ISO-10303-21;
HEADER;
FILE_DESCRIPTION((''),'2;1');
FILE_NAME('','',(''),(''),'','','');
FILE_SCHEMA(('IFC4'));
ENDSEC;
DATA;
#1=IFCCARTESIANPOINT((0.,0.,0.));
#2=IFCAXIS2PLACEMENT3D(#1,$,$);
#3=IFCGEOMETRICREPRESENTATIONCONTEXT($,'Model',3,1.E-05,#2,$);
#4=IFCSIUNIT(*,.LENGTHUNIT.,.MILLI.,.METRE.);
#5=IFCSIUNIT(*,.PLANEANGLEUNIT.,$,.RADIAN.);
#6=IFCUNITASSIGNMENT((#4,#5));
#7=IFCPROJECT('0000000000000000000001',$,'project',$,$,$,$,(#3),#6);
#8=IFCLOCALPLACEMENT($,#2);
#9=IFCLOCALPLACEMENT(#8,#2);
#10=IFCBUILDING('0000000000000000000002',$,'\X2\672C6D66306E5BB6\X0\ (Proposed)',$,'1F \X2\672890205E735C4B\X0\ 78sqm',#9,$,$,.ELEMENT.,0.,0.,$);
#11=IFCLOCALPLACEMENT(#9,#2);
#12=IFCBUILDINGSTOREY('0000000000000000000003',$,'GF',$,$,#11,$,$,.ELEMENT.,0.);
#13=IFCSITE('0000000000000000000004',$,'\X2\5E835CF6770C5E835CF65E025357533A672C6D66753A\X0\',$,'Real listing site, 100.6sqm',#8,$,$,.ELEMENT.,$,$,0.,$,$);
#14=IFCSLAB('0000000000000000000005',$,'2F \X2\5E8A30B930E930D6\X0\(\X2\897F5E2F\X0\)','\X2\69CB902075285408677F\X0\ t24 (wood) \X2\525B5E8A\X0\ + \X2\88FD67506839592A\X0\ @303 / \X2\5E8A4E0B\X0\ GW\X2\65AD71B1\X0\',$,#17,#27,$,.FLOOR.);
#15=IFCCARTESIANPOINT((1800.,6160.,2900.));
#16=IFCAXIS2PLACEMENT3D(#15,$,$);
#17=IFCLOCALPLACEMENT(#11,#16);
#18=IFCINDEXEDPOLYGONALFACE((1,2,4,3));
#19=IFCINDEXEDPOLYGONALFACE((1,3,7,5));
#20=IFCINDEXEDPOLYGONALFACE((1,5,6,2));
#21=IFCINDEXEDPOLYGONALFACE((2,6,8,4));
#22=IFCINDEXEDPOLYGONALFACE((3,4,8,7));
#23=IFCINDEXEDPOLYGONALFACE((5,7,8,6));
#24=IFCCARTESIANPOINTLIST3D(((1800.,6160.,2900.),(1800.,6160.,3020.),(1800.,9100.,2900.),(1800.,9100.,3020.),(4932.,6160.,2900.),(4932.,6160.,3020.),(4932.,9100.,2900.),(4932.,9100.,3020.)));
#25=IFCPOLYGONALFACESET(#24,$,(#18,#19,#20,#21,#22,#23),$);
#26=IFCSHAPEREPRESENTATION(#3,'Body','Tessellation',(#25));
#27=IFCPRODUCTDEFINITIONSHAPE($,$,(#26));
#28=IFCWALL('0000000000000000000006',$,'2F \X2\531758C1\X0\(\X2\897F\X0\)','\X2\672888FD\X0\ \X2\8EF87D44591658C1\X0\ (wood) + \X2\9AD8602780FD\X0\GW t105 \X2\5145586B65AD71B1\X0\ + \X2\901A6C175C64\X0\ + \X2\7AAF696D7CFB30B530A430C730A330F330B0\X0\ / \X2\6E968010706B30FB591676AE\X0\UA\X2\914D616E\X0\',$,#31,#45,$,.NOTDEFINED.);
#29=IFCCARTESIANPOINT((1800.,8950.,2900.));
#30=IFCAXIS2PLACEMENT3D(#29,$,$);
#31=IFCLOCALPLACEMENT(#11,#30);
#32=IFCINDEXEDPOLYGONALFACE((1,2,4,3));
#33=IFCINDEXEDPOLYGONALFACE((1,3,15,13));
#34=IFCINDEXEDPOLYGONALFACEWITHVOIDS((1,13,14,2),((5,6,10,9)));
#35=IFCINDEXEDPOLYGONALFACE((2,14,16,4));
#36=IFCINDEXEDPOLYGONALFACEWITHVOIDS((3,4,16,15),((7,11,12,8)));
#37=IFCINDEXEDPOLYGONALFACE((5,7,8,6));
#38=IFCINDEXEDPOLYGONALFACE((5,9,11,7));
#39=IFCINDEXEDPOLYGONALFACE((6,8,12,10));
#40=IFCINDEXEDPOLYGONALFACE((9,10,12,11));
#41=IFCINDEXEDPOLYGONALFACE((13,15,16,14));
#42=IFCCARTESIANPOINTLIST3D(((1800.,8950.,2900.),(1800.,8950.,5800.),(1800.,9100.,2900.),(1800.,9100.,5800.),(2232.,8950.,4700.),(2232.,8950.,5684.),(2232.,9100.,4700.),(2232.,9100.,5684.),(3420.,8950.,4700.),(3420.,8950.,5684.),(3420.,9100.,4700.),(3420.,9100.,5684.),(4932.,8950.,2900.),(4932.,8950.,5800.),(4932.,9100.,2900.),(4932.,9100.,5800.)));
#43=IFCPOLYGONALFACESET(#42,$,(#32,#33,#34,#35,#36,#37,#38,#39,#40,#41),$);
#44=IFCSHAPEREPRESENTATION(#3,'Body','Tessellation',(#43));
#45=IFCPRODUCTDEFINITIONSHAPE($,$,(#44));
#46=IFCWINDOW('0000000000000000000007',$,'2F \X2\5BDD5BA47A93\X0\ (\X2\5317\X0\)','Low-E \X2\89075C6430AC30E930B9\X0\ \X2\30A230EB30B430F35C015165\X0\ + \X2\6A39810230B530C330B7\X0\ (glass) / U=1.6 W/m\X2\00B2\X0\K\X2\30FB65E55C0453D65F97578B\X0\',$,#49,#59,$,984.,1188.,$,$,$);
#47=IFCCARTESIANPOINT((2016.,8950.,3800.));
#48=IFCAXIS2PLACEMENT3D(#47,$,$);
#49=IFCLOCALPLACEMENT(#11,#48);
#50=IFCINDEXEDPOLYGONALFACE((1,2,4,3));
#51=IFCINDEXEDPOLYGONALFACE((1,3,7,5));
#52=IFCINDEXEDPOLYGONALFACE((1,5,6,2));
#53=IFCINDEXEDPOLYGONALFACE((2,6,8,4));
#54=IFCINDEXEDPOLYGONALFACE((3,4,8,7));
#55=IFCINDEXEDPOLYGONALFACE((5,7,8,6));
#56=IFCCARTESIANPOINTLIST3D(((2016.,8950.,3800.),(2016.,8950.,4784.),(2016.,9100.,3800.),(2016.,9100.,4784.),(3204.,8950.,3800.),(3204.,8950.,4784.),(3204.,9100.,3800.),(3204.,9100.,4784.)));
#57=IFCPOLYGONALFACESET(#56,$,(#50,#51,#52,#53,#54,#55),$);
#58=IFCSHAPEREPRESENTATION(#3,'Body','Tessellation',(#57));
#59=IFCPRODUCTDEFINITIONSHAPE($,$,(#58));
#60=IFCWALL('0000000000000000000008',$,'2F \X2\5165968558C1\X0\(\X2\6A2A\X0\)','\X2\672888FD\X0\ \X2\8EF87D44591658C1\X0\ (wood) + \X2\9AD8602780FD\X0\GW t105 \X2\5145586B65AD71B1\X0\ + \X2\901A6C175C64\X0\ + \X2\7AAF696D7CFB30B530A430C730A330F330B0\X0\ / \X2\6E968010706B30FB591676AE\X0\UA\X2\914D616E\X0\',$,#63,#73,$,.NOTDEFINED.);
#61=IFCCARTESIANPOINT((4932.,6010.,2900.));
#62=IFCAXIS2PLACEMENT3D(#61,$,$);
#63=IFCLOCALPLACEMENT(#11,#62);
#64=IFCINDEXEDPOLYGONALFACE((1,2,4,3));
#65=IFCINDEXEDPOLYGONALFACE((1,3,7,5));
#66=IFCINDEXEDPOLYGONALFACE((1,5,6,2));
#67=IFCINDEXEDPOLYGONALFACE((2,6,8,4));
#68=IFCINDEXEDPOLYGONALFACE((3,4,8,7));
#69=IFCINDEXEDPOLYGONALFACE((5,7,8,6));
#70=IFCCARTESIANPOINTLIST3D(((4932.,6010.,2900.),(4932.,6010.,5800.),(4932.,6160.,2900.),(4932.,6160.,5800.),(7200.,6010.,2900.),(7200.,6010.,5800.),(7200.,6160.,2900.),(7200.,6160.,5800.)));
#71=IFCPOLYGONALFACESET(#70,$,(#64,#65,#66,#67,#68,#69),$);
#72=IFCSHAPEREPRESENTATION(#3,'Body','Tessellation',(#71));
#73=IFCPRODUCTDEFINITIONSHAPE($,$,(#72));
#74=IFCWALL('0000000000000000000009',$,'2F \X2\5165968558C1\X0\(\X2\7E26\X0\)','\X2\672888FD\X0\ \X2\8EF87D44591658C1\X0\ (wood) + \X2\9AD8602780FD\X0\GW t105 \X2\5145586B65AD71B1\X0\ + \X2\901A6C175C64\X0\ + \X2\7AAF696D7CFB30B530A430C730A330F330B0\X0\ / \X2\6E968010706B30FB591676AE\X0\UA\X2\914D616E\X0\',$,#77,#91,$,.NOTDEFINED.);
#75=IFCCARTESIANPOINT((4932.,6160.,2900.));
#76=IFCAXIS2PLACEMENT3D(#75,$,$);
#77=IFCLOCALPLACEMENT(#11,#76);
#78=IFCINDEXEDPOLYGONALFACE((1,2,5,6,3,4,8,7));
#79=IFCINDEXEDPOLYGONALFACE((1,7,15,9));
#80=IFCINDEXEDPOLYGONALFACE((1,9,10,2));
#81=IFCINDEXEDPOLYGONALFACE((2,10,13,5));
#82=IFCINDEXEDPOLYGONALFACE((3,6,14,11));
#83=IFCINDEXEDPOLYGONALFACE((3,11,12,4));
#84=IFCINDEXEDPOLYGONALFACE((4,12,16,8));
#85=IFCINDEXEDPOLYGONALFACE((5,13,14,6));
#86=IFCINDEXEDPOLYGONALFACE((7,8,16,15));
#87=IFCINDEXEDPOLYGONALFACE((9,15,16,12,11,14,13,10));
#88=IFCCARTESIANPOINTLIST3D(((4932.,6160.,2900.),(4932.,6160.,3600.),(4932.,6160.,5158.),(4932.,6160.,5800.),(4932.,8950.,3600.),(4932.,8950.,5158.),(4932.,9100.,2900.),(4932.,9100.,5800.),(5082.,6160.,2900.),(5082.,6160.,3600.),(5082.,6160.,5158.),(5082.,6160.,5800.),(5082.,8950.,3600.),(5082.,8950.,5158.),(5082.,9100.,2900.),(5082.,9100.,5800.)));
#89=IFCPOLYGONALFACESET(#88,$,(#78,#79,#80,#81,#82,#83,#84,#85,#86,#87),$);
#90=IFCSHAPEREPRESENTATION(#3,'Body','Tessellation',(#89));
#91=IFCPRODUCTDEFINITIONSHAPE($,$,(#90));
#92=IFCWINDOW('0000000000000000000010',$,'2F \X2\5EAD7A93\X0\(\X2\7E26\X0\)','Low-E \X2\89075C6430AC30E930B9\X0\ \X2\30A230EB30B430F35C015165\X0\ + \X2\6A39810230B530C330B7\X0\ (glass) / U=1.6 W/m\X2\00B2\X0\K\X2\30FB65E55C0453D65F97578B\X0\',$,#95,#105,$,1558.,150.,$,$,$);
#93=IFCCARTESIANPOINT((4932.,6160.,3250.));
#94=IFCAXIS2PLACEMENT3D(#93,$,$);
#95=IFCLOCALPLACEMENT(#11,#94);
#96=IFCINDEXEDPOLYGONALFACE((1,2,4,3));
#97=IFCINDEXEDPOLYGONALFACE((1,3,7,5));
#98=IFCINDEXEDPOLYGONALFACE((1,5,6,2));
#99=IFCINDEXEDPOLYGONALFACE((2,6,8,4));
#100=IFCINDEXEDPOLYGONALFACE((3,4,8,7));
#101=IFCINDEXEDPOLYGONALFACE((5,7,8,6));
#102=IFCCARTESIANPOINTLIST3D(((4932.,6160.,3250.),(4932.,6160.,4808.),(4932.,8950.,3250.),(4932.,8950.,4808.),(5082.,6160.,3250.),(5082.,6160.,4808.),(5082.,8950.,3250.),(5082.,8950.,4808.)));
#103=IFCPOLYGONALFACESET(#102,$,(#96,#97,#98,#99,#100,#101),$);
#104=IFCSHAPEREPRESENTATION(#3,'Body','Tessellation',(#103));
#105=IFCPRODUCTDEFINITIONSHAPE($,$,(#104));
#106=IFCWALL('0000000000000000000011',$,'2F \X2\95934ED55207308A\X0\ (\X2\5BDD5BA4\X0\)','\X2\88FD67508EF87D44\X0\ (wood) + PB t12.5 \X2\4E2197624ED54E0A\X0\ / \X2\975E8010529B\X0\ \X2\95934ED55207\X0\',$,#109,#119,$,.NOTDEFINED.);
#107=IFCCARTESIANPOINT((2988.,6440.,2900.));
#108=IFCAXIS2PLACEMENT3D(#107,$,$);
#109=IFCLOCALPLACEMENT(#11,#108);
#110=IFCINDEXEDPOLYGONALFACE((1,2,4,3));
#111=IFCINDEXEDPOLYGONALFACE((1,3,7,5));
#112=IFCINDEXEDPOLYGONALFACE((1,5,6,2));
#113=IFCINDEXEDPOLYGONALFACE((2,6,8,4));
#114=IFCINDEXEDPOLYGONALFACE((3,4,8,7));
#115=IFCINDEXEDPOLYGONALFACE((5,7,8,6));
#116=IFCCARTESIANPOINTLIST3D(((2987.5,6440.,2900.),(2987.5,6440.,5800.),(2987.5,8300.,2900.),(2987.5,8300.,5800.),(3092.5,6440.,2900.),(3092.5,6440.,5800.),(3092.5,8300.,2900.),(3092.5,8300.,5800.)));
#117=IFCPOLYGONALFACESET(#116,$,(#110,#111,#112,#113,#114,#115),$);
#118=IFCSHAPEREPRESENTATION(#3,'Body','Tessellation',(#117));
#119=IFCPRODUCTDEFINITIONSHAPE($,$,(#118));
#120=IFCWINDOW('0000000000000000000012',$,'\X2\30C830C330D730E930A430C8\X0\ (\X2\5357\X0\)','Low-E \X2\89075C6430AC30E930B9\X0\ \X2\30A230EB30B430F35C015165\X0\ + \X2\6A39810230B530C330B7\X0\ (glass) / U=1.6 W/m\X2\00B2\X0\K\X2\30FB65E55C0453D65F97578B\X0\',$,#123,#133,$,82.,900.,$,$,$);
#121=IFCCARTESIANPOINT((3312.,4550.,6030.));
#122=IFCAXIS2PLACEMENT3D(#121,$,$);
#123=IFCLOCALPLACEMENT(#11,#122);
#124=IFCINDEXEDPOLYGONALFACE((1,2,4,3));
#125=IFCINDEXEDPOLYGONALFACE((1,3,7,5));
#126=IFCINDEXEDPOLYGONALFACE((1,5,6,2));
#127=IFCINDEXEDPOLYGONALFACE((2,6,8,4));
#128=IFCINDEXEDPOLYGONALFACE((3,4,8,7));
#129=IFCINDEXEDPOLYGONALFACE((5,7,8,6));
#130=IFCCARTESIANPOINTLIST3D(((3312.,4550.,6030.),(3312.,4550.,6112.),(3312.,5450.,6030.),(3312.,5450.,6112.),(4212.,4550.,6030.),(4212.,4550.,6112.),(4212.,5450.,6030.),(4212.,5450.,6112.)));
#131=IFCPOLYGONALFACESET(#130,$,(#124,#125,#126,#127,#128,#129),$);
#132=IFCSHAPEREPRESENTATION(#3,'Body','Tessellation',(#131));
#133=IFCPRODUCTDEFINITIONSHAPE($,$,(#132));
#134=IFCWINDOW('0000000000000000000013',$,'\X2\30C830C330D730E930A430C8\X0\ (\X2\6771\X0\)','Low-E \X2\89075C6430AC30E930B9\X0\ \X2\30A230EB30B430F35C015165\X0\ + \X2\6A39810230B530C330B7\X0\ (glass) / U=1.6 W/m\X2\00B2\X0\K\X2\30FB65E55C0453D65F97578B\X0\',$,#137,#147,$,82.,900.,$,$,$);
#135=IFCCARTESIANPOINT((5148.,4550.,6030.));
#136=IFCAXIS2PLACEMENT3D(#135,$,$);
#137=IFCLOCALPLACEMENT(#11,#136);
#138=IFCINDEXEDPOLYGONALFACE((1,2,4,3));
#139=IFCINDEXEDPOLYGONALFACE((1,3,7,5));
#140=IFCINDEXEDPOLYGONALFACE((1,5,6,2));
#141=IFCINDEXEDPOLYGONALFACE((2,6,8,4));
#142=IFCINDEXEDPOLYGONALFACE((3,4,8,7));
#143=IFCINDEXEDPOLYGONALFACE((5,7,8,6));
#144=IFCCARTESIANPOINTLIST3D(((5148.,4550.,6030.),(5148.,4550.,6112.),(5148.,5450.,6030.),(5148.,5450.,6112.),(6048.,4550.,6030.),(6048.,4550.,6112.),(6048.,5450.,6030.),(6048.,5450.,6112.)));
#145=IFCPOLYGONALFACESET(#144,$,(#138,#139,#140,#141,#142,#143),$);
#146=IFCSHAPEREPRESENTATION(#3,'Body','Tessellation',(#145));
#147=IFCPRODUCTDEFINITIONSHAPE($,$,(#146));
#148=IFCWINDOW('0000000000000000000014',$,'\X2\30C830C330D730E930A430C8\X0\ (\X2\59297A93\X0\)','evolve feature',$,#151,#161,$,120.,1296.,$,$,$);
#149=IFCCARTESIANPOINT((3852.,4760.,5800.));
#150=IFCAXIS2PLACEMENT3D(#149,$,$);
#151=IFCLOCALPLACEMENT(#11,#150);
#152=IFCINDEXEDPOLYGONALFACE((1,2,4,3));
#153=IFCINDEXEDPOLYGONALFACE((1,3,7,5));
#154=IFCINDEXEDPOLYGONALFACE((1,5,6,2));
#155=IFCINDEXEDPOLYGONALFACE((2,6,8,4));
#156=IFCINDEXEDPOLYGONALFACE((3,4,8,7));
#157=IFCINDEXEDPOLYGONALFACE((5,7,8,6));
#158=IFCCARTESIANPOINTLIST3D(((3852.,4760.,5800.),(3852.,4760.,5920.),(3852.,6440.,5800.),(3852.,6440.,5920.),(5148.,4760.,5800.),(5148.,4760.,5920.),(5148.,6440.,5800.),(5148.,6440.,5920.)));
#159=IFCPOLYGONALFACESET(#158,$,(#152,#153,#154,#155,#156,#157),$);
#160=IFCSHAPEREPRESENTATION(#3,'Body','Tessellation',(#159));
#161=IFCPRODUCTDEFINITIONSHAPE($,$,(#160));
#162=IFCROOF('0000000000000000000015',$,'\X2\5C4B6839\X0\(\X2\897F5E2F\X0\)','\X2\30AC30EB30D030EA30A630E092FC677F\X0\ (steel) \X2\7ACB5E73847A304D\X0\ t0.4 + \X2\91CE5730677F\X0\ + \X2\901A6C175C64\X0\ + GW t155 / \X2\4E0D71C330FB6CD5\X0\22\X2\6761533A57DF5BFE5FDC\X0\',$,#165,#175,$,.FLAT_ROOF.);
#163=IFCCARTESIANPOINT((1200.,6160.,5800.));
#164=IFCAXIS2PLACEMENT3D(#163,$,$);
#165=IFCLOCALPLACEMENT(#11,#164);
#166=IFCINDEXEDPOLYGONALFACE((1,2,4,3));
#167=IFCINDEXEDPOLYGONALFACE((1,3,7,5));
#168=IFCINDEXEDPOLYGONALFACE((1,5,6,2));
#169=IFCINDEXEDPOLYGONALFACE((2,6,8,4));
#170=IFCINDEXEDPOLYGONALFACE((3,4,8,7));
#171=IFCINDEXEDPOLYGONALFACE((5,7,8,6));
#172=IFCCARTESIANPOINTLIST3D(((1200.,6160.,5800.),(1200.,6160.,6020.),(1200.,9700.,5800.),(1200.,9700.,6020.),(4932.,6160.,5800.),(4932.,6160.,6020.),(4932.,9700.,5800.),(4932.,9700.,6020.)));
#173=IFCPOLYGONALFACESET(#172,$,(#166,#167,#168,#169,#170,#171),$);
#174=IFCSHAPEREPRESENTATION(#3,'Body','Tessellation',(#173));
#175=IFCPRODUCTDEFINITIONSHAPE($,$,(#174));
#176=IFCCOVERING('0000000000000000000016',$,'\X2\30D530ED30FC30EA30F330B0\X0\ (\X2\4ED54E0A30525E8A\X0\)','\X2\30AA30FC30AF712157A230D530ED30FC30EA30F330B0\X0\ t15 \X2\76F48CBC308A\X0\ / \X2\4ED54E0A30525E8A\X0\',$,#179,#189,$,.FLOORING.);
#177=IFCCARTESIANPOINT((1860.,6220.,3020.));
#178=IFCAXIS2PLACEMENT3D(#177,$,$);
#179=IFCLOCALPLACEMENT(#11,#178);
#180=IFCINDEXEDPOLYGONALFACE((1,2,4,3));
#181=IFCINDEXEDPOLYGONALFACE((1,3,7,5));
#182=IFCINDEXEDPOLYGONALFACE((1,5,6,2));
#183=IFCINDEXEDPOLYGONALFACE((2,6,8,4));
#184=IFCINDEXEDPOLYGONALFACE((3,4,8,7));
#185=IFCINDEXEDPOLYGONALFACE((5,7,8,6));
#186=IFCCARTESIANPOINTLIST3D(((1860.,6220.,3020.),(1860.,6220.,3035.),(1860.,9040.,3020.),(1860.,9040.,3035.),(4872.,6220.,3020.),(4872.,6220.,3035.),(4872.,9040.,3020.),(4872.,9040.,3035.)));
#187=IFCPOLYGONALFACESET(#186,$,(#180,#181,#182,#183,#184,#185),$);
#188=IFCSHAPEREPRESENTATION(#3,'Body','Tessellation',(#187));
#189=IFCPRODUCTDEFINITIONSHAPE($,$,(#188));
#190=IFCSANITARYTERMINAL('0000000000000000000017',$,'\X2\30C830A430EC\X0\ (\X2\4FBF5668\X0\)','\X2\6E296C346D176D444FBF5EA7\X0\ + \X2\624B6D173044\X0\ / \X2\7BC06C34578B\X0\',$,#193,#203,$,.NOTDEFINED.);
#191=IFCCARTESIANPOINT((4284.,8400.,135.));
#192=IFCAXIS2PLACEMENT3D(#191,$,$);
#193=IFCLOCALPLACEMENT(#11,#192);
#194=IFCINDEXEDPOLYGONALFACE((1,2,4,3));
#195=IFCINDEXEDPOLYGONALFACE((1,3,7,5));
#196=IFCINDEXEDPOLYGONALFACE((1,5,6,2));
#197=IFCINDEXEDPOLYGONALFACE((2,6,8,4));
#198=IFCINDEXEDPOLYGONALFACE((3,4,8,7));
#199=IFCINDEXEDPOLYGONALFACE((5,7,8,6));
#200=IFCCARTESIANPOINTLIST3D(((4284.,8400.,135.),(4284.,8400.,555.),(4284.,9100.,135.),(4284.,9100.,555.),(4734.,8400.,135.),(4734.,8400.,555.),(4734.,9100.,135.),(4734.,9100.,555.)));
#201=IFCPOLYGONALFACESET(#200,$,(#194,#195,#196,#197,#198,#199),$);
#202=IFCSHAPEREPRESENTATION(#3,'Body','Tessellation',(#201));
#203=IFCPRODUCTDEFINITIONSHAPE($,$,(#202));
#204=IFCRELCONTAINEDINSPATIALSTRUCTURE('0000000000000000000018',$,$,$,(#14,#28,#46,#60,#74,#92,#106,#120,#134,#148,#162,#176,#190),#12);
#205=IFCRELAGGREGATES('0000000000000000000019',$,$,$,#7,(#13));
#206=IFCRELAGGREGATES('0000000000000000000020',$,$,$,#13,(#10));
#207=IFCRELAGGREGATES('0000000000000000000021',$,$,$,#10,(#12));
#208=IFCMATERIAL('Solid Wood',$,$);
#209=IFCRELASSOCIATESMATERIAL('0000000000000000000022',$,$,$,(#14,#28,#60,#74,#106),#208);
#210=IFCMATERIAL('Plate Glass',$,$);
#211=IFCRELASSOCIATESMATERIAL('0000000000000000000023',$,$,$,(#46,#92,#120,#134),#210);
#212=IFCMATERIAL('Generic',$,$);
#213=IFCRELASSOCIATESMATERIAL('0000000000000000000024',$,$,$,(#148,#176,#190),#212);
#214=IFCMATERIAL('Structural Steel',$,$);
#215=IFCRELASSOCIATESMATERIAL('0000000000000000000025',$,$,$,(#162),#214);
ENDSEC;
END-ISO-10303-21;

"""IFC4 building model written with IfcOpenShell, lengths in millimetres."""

from ifc_helpers import new_model, si_unit, frame, frame_2d, origin, place, context, project, spatial, rectangle, extrude, material, element, fill, save


model = new_model("IFC4")

# Units and contexts
model_context = context("Model", 3, precision=1e-05, world=origin())
ifc_project = project(units=[si_unit("LENGTHUNIT", "METRE", prefix="MILLI"), si_unit("PLANEANGLEUNIT", "RADIAN")], contexts=[model_context])

# Site, building, storey
site_placement = place(None, origin())
site = spatial("IfcSite", under=ifc_project, at=site_placement, Name="広島県広島市南区本浦町", ObjectType="Real listing site, 100.6sqm", CompositionType="ELEMENT", RefElevation=0.0)
building_placement = place(site_placement, origin())
building = spatial("IfcBuilding", under=site, at=building_placement, Name="本浦の家 (Proposed)", ObjectType="1F 木造平屋 78sqm", CompositionType="ELEMENT", ElevationOfRefHeight=0.0, ElevationOfTerrain=0.0)
storey_placement = place(building_placement, origin())
storey = spatial("IfcBuildingStorey", under=building, at=storey_placement, Name="GF", CompositionType="ELEMENT", Elevation=0.0)

# Slab
ifc_material_1 = material(Name="Solid Wood")
slab_placement = place(storey_placement, frame((1800.0, 6160.0, 2900.0)))
element("IfcSlab", 1, at=slab_placement, inside=storey, material=ifc_material_1, Name="2F 床スラブ(西帯)", Description="構造用合板 t24 (wood) 剛床 + 製材根太 @303 / 床下 GW断熱", PredefinedType="FLOOR", context=model_context, shape_type="SweptSolid", body=[
    extrude(rectangle(XDim=3132.0, YDim=2940.0, at=frame_2d((1566.0, 1470.0))), frame((1800.0, 6160.0, 2900.0)), (0.0, 0.0, 1.0), 120.0),
])

# Wall, opening, window
wall_1_placement = place(storey_placement, frame((1800.0, 8950.0, 2900.0)))
wall_1 = element("IfcWall", 2, at=wall_1_placement, inside=storey, material=ifc_material_1, Name="2F 北壁(西)", Description="木製 軸組外壁 (wood) + 高性能GW t105 充填断熱 + 通気層 + 窯業系サイディング / 準耐火・外皮UA配慮", PredefinedType="NOTDEFINED", context=model_context, shape_type="SweptSolid", body=[
    extrude(rectangle(XDim=3132.0, YDim=150.0, at=frame_2d((1566.0, 75.0))), frame((1800.0, 8950.0, 2900.0)), (0.0, 0.0, 1.0), 2900.0),
])
opening_1_placement = place(storey_placement, frame((2016.0, 8950.0, 3800.0)))
opening_1 = element("IfcOpeningElement", 3, at=opening_1_placement, cuts=wall_1, PredefinedType="NOTDEFINED", context=model_context, shape_type="SweptSolid", body=[
    extrude(rectangle(XDim=1188.0, YDim=150.0, at=frame_2d((594.0, 75.0))), frame((2016.0, 8950.0, 3800.0)), (0.0, 0.0, 1.0), 984.0),
])
ifc_material_2 = material(Name="Plate Glass")
window_1_placement = place(storey_placement, frame((2016.0, 8950.0, 3800.0)))
window_1 = element("IfcWindow", 4, at=window_1_placement, inside=storey, material=ifc_material_2, Name="2F 寝室窓 (北)", Description="Low-E 複層ガラス アルゴン封入 + 樹脂サッシ (glass) / U=1.6 W/m²K・日射取得型", OverallHeight=984.0, OverallWidth=1188.0, context=model_context, shape_type="SweptSolid", body=[
    extrude(rectangle(XDim=1188.0, YDim=150.0, at=frame_2d((594.0, 75.0))), frame((2016.0, 8950.0, 3800.0)), (0.0, 0.0, 1.0), 984.0),
])
fill(opening_1, window_1)

# Wall
wall_2_placement = place(storey_placement, frame((4932.0, 6010.0, 2900.0)))
element("IfcWall", 5, at=wall_2_placement, inside=storey, material=ifc_material_1, Name="2F 入隅壁(横)", Description="木製 軸組外壁 (wood) + 高性能GW t105 充填断熱 + 通気層 + 窯業系サイディング / 準耐火・外皮UA配慮", PredefinedType="NOTDEFINED", context=model_context, shape_type="SweptSolid", body=[
    extrude(rectangle(XDim=2268.0, YDim=150.0, at=frame_2d((1134.0, 75.0))), frame((4932.0, 6010.0, 2900.0)), (0.0, 0.0, 1.0), 2900.0),
])

# Wall, opening, window
wall_3_placement = place(storey_placement, frame((4932.0, 6160.0, 2900.0)))
wall_3 = element("IfcWall", 6, at=wall_3_placement, inside=storey, material=ifc_material_1, Name="2F 入隅壁(縦)", Description="木製 軸組外壁 (wood) + 高性能GW t105 充填断熱 + 通気層 + 窯業系サイディング / 準耐火・外皮UA配慮", PredefinedType="NOTDEFINED", context=model_context, shape_type="SweptSolid", body=[
    extrude(rectangle(XDim=150.0, YDim=2940.0, at=frame_2d((75.0, 1470.0))), frame((4932.0, 6160.0, 2900.0)), (0.0, 0.0, 1.0), 2900.0),
])
opening_2_placement = place(storey_placement, frame((4932.0, 6160.0, 3250.0)))
opening_2 = element("IfcOpeningElement", 7, at=opening_2_placement, cuts=wall_3, PredefinedType="NOTDEFINED", context=model_context, shape_type="SweptSolid", body=[
    extrude(rectangle(XDim=150.0, YDim=2790.0, at=frame_2d((75.0, 1395.0))), frame((4932.0, 6160.0, 3250.0)), (0.0, 0.0, 1.0), 1558.0),
])
window_2_placement = place(storey_placement, frame((4932.0, 6160.0, 3250.0)))
window_2 = element("IfcWindow", 8, at=window_2_placement, inside=storey, material=ifc_material_2, Name="2F 庭窓(縦)", Description="Low-E 複層ガラス アルゴン封入 + 樹脂サッシ (glass) / U=1.6 W/m²K・日射取得型", OverallHeight=1558.0, OverallWidth=150.0, context=model_context, shape_type="SweptSolid", body=[
    extrude(rectangle(XDim=150.0, YDim=2790.0, at=frame_2d((75.0, 1395.0))), frame((4932.0, 6160.0, 3250.0)), (0.0, 0.0, 1.0), 1558.0),
])
fill(opening_2, window_2)

# Wall
wall_4_placement = place(storey_placement, frame((2988.0, 6440.0, 2900.0)))
element("IfcWall", 9, at=wall_4_placement, inside=storey, material=ifc_material_1, Name="2F 間仕切り (寝室)", Description="製材軸組 (wood) + PB t12.5 両面仕上 / 非耐力 間仕切", PredefinedType="NOTDEFINED", context=model_context, shape_type="SweptSolid", body=[
    extrude(rectangle(XDim=105.0, YDim=1860.0, at=frame_2d((52.0, 930.0))), frame((2988.0, 6440.0, 2900.0)), (0.0, 0.0, 1.0), 2900.0),
])

# Windows
window_3_placement = place(storey_placement, frame((3312.0, 4550.0, 6030.0)))
element("IfcWindow", 10, at=window_3_placement, inside=storey, material=ifc_material_2, Name="トップライト (南)", Description="Low-E 複層ガラス アルゴン封入 + 樹脂サッシ (glass) / U=1.6 W/m²K・日射取得型", OverallHeight=82.0, OverallWidth=900.0, context=model_context, shape_type="SweptSolid", body=[
    extrude(rectangle(XDim=900.0, YDim=900.0, at=frame_2d((450.0, 450.0))), frame((3312.0, 4550.0, 6030.0)), (0.0, 0.0, 1.0), 82.0),
])
window_4_placement = place(storey_placement, frame((5148.0, 4550.0, 6030.0)))
element("IfcWindow", 11, at=window_4_placement, inside=storey, material=ifc_material_2, Name="トップライト (東)", Description="Low-E 複層ガラス アルゴン封入 + 樹脂サッシ (glass) / U=1.6 W/m²K・日射取得型", OverallHeight=82.0, OverallWidth=900.0, context=model_context, shape_type="SweptSolid", body=[
    extrude(rectangle(XDim=900.0, YDim=900.0, at=frame_2d((450.0, 450.0))), frame((5148.0, 4550.0, 6030.0)), (0.0, 0.0, 1.0), 82.0),
])
ifc_material_3 = material(Name="Generic")
window_5_placement = place(storey_placement, frame((3852.0, 4760.0, 5800.0)))
element("IfcWindow", 12, at=window_5_placement, inside=storey, material=ifc_material_3, Name="トップライト (天窓)", Description="evolve feature", OverallHeight=120.0, OverallWidth=1296.0, context=model_context, shape_type="SweptSolid", body=[
    extrude(rectangle(XDim=1296.0, YDim=1680.0, at=frame_2d((648.0, 840.0))), frame((3852.0, 4760.0, 5800.0)), (0.0, 0.0, 1.0), 120.0),
])

# Roof
ifc_material_4 = material(Name="Structural Steel")
for number, where, name in (
    (13, (1200.0, 6160.0, 5800.0), "屋根(西帯)"),
):
    element("IfcRoof", number, at=place(storey_placement, frame(where)), inside=storey, material=ifc_material_4, Name=name, Description="ガルバリウム鋼板 (steel) 立平葺き t0.4 + 野地板 + 通気層 + GW t155 / 不燃・法22条区域対応", PredefinedType="FLAT_ROOF", context=model_context, shape_type="SweptSolid", body=[
        extrude(rectangle(XDim=3732.0, YDim=3540.0, at=frame_2d((1866.0, 1770.0))), frame((1200.0, 6160.0, 5800.0)), (0.0, 0.0, 1.0), 220.0),
    ])

# Covering
covering_placement = place(storey_placement, frame((1860.0, 6220.0, 3020.0)))
element("IfcCovering", 14, at=covering_placement, inside=storey, material=ifc_material_3, Name="フローリング (仕上げ床)", Description="オーク無垢フローリング t15 直貼り / 仕上げ床", PredefinedType="FLOORING", context=model_context, shape_type="SweptSolid", body=[
    extrude(rectangle(XDim=3012.0, YDim=2820.0, at=frame_2d((1506.0, 1410.0))), frame((1860.0, 6220.0, 3020.0)), (0.0, 0.0, 1.0), 15.0),
])

# Sanitary terminal
sanitary_terminal_placement = place(storey_placement, frame((4284.0, 8400.0, 135.0)))
element("IfcSanitaryTerminal", 15, at=sanitary_terminal_placement, inside=storey, material=ifc_material_3, Name="トイレ (便器)", Description="温水洗浄便座 + 手洗い / 節水型", PredefinedType="NOTDEFINED", context=model_context, shape_type="SweptSolid", body=[
    extrude(rectangle(XDim=450.0, YDim=700.0, at=frame_2d((225.0, 350.0))), frame((4284.0, 8400.0, 135.0)), (0.0, 0.0, 1.0), 420.0),
])

save(model, "model.ifc")
